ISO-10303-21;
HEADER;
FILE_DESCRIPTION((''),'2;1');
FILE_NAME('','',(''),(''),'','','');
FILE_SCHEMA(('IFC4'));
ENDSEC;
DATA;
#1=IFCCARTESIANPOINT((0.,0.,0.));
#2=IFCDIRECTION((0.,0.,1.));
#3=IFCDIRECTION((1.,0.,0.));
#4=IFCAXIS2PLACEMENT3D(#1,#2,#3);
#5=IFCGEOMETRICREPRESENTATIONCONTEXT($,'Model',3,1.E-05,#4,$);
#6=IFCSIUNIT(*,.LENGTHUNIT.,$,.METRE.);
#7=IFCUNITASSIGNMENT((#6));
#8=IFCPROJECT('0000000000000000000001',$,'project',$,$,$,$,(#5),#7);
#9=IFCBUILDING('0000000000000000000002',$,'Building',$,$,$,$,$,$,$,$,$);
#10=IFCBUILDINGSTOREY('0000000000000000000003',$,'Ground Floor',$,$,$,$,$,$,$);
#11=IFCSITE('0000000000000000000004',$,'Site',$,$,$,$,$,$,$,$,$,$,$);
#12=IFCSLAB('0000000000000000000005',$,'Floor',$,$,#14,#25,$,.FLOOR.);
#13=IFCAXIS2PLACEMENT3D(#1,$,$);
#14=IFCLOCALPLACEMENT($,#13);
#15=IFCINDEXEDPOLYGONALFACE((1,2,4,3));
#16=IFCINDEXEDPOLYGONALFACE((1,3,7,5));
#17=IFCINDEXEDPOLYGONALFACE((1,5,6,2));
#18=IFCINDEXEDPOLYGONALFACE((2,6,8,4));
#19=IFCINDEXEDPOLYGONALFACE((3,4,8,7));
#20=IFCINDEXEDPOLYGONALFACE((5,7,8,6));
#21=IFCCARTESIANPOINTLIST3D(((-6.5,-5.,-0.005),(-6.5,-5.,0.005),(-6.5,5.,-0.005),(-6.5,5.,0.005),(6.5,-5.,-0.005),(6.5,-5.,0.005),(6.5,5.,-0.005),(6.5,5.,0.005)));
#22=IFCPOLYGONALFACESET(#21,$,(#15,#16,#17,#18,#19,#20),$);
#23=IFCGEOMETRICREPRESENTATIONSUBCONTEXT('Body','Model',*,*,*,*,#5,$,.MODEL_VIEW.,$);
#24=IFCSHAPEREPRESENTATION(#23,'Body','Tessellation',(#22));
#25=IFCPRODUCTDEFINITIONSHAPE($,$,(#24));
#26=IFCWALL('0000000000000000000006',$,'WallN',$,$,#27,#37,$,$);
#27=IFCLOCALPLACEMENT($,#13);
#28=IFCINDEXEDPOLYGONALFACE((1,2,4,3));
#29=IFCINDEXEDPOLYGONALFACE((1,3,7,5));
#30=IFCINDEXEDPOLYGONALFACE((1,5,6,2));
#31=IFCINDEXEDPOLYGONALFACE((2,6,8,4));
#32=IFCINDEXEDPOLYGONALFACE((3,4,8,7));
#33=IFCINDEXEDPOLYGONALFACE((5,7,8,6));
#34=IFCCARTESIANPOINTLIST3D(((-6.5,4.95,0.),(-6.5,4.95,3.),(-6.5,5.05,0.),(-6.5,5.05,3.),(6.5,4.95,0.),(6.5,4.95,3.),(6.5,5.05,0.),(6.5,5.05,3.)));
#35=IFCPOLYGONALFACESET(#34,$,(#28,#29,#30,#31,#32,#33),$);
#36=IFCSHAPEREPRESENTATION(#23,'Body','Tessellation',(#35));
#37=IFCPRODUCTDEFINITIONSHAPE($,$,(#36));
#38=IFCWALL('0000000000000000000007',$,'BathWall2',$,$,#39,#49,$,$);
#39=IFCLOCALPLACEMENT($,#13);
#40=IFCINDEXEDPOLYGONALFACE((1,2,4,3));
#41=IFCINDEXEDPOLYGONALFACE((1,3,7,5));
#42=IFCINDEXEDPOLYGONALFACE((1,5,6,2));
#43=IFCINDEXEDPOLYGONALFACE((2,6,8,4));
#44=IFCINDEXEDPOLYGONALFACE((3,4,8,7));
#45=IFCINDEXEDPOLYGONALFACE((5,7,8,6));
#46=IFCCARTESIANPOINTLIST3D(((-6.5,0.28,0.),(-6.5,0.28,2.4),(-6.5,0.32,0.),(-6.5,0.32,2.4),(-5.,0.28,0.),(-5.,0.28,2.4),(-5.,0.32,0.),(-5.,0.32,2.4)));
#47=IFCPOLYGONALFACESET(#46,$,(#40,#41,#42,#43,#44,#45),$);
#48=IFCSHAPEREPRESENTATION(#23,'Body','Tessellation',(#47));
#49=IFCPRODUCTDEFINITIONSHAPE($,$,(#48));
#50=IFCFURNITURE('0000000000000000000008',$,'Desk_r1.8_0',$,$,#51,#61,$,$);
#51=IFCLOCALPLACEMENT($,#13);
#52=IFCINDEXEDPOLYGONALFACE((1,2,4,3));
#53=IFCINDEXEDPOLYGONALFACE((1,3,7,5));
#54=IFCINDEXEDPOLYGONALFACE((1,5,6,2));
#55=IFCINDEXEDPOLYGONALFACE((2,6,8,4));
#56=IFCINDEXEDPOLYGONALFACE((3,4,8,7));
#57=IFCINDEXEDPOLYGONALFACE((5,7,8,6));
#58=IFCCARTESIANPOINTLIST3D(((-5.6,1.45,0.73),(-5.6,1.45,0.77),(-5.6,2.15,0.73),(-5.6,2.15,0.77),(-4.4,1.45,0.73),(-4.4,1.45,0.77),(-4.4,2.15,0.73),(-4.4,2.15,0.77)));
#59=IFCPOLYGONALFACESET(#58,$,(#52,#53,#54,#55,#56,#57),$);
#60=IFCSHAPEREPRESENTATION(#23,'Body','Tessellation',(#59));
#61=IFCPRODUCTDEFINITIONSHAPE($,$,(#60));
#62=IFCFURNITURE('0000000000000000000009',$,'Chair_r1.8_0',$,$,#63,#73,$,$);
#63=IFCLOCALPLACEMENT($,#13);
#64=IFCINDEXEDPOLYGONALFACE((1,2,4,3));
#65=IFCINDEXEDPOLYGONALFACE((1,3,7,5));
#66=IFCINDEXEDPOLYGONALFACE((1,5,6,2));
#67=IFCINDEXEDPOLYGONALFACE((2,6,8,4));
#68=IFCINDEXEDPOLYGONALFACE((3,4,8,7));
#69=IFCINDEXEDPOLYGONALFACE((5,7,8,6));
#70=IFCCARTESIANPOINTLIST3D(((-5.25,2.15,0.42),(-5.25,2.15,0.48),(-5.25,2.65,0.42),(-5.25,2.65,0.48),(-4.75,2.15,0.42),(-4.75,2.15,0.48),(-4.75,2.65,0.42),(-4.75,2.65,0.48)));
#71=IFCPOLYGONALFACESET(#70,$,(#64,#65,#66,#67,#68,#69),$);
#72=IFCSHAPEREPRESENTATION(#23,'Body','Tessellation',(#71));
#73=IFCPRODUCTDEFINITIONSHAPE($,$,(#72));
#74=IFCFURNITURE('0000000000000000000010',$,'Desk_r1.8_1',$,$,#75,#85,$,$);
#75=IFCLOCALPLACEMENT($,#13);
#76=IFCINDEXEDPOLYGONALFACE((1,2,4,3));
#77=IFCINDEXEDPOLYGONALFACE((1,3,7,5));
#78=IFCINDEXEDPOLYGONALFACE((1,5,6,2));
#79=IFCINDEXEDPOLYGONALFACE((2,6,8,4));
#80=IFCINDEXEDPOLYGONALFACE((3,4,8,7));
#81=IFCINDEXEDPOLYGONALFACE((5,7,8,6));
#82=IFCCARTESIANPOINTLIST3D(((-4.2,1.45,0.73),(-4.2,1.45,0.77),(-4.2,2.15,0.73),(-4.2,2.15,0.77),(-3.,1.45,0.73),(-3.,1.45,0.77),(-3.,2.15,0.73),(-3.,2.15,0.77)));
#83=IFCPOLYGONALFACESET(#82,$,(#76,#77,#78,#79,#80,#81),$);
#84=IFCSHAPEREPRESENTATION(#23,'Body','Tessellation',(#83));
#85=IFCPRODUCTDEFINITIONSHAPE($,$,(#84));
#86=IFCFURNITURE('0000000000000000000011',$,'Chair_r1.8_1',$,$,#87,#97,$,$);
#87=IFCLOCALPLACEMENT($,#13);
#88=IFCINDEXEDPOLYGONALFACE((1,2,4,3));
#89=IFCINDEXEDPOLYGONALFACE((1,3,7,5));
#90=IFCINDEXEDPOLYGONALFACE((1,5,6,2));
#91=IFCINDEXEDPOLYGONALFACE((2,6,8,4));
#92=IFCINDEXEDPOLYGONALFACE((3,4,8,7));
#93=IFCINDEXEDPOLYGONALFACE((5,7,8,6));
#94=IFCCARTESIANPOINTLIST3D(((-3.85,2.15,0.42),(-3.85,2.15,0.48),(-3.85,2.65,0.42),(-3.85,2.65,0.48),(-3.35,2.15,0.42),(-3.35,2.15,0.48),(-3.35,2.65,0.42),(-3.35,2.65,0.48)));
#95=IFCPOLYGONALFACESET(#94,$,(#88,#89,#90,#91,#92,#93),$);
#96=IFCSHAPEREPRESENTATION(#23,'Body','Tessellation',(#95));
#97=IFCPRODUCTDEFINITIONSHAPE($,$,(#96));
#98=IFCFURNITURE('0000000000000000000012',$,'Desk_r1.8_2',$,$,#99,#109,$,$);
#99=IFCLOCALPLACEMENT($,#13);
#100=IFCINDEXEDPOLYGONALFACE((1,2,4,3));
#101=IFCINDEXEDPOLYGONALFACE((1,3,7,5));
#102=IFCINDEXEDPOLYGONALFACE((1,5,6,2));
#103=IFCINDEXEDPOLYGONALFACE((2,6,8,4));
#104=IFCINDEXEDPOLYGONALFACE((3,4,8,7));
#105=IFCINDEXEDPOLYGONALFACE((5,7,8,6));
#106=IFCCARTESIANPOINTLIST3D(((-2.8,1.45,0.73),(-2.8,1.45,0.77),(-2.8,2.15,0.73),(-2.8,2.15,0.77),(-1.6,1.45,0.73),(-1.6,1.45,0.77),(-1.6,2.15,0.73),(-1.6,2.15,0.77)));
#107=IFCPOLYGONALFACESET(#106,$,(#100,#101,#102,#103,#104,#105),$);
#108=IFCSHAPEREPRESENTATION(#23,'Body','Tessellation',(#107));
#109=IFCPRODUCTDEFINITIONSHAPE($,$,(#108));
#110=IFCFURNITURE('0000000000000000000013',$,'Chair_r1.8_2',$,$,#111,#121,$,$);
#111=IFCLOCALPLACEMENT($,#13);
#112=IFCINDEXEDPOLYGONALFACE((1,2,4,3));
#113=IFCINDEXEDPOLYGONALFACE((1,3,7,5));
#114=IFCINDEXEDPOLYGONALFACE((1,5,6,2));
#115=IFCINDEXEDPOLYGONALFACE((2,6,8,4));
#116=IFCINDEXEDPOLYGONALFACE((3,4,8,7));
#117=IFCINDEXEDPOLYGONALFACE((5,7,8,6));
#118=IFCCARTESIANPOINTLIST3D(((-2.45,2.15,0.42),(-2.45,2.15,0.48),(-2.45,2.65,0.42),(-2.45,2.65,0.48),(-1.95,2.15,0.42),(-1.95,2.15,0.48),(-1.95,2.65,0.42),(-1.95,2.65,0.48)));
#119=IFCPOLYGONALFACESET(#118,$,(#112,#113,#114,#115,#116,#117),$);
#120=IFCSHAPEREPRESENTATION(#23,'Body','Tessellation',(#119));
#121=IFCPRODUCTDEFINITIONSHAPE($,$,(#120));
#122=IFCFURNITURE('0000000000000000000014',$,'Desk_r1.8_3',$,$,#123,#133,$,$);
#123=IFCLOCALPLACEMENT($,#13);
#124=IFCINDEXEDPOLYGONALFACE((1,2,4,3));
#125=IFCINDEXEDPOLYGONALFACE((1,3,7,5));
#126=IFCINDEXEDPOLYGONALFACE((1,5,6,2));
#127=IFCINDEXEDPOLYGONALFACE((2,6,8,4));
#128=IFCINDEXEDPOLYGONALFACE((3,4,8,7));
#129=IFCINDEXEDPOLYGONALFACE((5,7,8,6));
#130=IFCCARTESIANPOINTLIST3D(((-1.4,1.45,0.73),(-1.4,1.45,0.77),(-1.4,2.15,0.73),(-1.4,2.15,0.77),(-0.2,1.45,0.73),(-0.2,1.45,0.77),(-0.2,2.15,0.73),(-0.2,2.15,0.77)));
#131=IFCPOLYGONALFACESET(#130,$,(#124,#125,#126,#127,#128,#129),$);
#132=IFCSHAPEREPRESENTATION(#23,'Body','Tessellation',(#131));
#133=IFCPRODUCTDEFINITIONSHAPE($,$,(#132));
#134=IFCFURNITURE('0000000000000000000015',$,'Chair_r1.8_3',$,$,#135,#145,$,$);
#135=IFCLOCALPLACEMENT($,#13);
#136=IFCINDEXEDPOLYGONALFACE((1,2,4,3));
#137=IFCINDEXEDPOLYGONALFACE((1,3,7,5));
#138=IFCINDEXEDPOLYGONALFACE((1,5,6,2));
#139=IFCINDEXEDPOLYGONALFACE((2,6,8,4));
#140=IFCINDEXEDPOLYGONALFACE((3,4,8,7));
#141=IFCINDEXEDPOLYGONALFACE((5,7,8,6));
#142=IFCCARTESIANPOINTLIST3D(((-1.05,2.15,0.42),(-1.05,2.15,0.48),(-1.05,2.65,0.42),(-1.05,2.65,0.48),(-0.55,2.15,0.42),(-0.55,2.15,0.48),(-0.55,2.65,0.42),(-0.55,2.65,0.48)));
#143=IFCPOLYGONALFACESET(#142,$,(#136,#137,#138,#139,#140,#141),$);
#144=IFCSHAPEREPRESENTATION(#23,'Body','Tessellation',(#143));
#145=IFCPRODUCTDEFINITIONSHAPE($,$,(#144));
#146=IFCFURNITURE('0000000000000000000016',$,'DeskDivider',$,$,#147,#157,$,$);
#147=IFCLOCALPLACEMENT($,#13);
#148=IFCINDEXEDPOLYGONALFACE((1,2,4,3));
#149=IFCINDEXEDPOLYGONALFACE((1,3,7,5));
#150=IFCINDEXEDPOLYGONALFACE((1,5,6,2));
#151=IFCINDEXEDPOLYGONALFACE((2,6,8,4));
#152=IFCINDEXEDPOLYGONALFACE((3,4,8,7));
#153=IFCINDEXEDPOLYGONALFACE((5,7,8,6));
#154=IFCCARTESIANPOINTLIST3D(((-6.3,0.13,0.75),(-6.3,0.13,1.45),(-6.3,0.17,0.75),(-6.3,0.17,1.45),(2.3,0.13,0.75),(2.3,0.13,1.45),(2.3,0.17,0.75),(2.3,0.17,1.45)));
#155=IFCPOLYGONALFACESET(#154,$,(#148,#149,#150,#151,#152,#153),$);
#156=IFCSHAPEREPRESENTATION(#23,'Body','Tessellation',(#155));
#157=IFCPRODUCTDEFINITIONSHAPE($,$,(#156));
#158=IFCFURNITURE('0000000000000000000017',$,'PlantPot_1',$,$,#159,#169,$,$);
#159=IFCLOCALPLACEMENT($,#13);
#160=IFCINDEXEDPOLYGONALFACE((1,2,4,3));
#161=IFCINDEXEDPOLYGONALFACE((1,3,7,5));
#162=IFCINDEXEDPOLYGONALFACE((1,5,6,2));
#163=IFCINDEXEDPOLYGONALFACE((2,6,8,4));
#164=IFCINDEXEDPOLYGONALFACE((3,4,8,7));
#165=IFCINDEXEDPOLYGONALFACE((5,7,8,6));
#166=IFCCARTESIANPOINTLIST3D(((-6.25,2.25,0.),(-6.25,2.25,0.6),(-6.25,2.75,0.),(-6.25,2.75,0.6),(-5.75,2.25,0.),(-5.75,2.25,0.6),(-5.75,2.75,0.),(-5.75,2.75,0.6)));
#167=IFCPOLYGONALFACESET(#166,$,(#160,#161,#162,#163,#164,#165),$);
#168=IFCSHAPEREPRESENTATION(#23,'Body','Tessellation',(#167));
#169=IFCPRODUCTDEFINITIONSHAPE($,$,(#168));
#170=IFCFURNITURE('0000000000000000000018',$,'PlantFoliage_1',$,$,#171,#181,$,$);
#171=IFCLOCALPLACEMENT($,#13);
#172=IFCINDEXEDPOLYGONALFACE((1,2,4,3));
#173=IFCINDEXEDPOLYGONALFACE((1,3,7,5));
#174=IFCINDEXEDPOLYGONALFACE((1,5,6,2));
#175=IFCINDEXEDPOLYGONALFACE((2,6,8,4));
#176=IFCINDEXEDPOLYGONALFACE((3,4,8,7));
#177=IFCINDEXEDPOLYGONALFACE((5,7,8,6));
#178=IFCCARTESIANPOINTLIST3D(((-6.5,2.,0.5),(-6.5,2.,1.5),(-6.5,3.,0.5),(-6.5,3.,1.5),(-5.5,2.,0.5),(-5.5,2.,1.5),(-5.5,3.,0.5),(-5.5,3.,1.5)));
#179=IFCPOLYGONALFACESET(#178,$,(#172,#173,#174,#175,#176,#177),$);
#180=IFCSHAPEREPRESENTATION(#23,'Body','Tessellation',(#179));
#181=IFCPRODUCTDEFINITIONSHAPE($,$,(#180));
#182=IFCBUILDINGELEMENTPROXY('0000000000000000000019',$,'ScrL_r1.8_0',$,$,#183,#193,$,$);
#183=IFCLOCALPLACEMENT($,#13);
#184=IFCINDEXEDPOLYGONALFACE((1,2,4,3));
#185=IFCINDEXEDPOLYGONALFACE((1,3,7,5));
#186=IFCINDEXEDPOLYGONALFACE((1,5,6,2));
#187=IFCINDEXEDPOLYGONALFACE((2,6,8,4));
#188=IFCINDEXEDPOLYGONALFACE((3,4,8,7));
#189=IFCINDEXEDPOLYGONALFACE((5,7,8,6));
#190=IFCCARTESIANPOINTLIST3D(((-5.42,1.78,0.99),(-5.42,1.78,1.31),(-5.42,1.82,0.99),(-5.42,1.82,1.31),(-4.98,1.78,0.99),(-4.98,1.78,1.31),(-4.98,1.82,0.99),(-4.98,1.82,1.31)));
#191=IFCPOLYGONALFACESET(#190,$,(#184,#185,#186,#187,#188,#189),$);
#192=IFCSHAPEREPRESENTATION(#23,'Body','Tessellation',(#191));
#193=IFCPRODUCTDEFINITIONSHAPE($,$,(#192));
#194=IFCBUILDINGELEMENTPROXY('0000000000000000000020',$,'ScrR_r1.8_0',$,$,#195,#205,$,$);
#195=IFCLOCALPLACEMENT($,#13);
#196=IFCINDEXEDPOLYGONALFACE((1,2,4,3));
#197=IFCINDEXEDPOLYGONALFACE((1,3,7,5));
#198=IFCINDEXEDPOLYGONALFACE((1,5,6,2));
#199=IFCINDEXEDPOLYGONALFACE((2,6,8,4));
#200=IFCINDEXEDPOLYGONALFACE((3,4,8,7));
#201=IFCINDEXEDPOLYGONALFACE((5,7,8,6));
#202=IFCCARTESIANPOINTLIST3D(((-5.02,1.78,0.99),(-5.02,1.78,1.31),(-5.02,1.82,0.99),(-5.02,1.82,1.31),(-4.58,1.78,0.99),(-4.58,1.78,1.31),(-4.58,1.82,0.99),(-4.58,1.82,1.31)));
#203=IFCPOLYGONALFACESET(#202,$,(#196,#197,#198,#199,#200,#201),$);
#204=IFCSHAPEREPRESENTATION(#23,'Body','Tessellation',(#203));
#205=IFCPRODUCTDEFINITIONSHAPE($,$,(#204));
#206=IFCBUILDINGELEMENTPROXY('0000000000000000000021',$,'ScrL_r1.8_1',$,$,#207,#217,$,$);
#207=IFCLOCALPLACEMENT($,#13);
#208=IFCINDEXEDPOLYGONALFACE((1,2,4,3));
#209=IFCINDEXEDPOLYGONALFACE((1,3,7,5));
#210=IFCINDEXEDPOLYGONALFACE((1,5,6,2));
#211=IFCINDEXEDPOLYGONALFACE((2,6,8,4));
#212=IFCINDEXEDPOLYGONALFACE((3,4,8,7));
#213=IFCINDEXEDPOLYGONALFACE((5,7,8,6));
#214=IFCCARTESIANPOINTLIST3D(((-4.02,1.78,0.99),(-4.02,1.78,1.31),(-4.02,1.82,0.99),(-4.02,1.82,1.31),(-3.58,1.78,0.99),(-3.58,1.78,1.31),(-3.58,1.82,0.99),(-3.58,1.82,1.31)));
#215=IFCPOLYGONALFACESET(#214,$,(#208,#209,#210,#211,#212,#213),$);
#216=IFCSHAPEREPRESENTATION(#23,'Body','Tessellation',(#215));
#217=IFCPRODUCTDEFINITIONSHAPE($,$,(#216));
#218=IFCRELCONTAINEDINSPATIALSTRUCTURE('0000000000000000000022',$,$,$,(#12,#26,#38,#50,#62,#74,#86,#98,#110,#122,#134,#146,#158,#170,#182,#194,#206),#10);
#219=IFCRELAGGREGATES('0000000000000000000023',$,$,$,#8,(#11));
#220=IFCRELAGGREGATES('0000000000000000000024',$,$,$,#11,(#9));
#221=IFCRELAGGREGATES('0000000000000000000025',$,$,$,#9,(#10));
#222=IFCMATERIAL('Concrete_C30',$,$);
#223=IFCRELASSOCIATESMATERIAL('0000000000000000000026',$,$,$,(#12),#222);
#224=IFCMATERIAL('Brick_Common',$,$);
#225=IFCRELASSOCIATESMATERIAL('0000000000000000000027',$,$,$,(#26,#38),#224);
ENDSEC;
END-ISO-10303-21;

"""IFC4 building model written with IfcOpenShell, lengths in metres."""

from ifc_helpers import new_model, si_unit, frame, origin_with_axes, origin_2d, place, context, subcontext, project, spatial, rectangle, extrude, material, element, save


model = new_model("IFC4")

# Units and contexts
model_context = context("Model", 3, precision=1e-05, world=origin_with_axes())
body_context = subcontext(model_context, "Body", "Model", "MODEL_VIEW")
ifc_project = project(units=[si_unit("LENGTHUNIT", "METRE")], contexts=[model_context])

# Site, building, storey
site = spatial("IfcSite", under=ifc_project, Name="Site")
building = spatial("IfcBuilding", under=site, Name="Building")
storey = spatial("IfcBuildingStorey", under=building, Name="Ground Floor")

# Slab
ifc_material_1 = material(Name="Concrete_C30")
slab_placement = place(None, origin_with_axes())
element("IfcSlab", 1, at=slab_placement, inside=storey, material=ifc_material_1, Name="Floor", PredefinedType="FLOOR", context=body_context, shape_type="SweptSolid", body=[
    extrude(rectangle(XDim=13.0, YDim=10.0, at=origin_2d()), frame((0.0, 0.0, -0.005)), (0.0, 0.0, 1.0), 0.01),
])

# Walls
ifc_material_2 = material(Name="Brick_Common")
wall_1_placement = place(None, frame((0.0, 5.0, 1.5), z_axis=(0.0, 0.0, 1.0), x_axis=(1.0, 0.0, 0.0)))
element("IfcWall", 2, at=wall_1_placement, inside=storey, material=ifc_material_2, Name="WallN", context=body_context, shape_type="SweptSolid", body=[
    extrude(rectangle(XDim=13.0, YDim=0.1, at=origin_2d()), frame((0.0, 0.0, -1.5)), (0.0, 0.0, 1.0), 3.0),
])
wall_2_placement = place(None, frame((-5.75, 0.3, 1.2), z_axis=(0.0, 0.0, 1.0), x_axis=(1.0, 0.0, 0.0)))
element("IfcWall", 3, at=wall_2_placement, inside=storey, material=ifc_material_2, Name="BathWall2", context=body_context, shape_type="SweptSolid", body=[
    extrude(rectangle(XDim=1.5, YDim=0.04, at=origin_2d()), frame((0.0, 0.0, -1.2)), (0.0, 0.0, 1.0), 2.4),
])

# Furniture
furniture_1_placement = place(None, frame((-5.0, 1.8, 0.75), z_axis=(0.0, 0.0, 1.0), x_axis=(1.0, 0.0, 0.0)))
element("IfcFurniture", 4, at=furniture_1_placement, inside=storey, Name="Desk_r1.8_0", context=body_context, shape_type="SweptSolid", body=[
    extrude(rectangle(XDim=1.2, YDim=0.7, at=origin_2d()), frame((0.0, 0.0, -0.02)), (0.0, 0.0, 1.0), 0.04),
])
furniture_2_placement = place(None, frame((-5.0, 2.4, 0.45), z_axis=(0.0, 0.0, 1.0), x_axis=(1.0, 0.0, 0.0)))
element("IfcFurniture", 5, at=furniture_2_placement, inside=storey, Name="Chair_r1.8_0", context=body_context, shape_type="SweptSolid", body=[
    extrude(rectangle(XDim=0.5, YDim=0.5, at=origin_2d()), frame((0.0, 0.0, -0.03)), (0.0, 0.0, 1.0), 0.06),
])
furniture_3_placement = place(None, frame((-3.6, 1.8, 0.75), z_axis=(0.0, 0.0, 1.0), x_axis=(1.0, 0.0, 0.0)))
element("IfcFurniture", 6, at=furniture_3_placement, inside=storey, Name="Desk_r1.8_1", context=body_context, shape_type="SweptSolid", body=[
    extrude(rectangle(XDim=1.2, YDim=0.7, at=origin_2d()), frame((0.0, 0.0, -0.02)), (0.0, 0.0, 1.0), 0.04),
])
furniture_4_placement = place(None, frame((-3.6, 2.4, 0.45), z_axis=(0.0, 0.0, 1.0), x_axis=(1.0, 0.0, 0.0)))
element("IfcFurniture", 7, at=furniture_4_placement, inside=storey, Name="Chair_r1.8_1", context=body_context, shape_type="SweptSolid", body=[
    extrude(rectangle(XDim=0.5, YDim=0.5, at=origin_2d()), frame((0.0, 0.0, -0.03)), (0.0, 0.0, 1.0), 0.06),
])
furniture_5_placement = place(None, frame((-2.2, 1.8, 0.75), z_axis=(0.0, 0.0, 1.0), x_axis=(1.0, 0.0, 0.0)))
element("IfcFurniture", 8, at=furniture_5_placement, inside=storey, Name="Desk_r1.8_2", context=body_context, shape_type="SweptSolid", body=[
    extrude(rectangle(XDim=1.2, YDim=0.7, at=origin_2d()), frame((0.0, 0.0, -0.02)), (0.0, 0.0, 1.0), 0.04),
])
furniture_6_placement = place(None, frame((-2.2, 2.4, 0.45), z_axis=(0.0, 0.0, 1.0), x_axis=(1.0, 0.0, 0.0)))
element("IfcFurniture", 9, at=furniture_6_placement, inside=storey, Name="Chair_r1.8_2", context=body_context, shape_type="SweptSolid", body=[
    extrude(rectangle(XDim=0.5, YDim=0.5, at=origin_2d()), frame((0.0, 0.0, -0.03)), (0.0, 0.0, 1.0), 0.06),
])
furniture_7_placement = place(None, frame((-0.8, 1.8, 0.75), z_axis=(0.0, 0.0, 1.0), x_axis=(1.0, 0.0, 0.0)))
element("IfcFurniture", 10, at=furniture_7_placement, inside=storey, Name="Desk_r1.8_3", context=body_context, shape_type="SweptSolid", body=[
    extrude(rectangle(XDim=1.2, YDim=0.7, at=origin_2d()), frame((0.0, 0.0, -0.02)), (0.0, 0.0, 1.0), 0.04),
])
furniture_8_placement = place(None, frame((-0.8, 2.4, 0.45), z_axis=(0.0, 0.0, 1.0), x_axis=(1.0, 0.0, 0.0)))
element("IfcFurniture", 11, at=furniture_8_placement, inside=storey, Name="Chair_r1.8_3", context=body_context, shape_type="SweptSolid", body=[
    extrude(rectangle(XDim=0.5, YDim=0.5, at=origin_2d()), frame((0.0, 0.0, -0.03)), (0.0, 0.0, 1.0), 0.06),
])
furniture_9_placement = place(None, frame((-2.0, 0.15, 1.1), z_axis=(0.0, 0.0, 1.0), x_axis=(1.0, 0.0, 0.0)))
element("IfcFurniture", 12, at=furniture_9_placement, inside=storey, Name="DeskDivider", context=body_context, shape_type="SweptSolid", body=[
    extrude(rectangle(XDim=8.6, YDim=0.04, at=origin_2d()), frame((0.0, 0.0, -0.35)), (0.0, 0.0, 1.0), 0.7),
])
furniture_10_placement = place(None, frame((-6.0, 2.5, 0.3), z_axis=(0.0, 0.0, 1.0), x_axis=(1.0, 0.0, 0.0)))
element("IfcFurniture", 13, at=furniture_10_placement, inside=storey, Name="PlantPot_1", context=body_context, shape_type="SweptSolid", body=[
    extrude(rectangle(XDim=0.5, YDim=0.5, at=origin_2d()), frame((0.0, 0.0, -0.3)), (0.0, 0.0, 1.0), 0.6),
])
furniture_11_placement = place(None, frame((-6.0, 2.5, 1.0), z_axis=(0.0, 0.0, 1.0), x_axis=(1.0, 0.0, 0.0)))
element("IfcFurniture", 14, at=furniture_11_placement, inside=storey, Name="PlantFoliage_1", context=body_context, shape_type="SweptSolid", body=[
    extrude(rectangle(XDim=1.0, YDim=1.0, at=origin_2d()), frame((0.0, 0.0, -0.5)), (0.0, 0.0, 1.0), 1.0),
])

# Building element proxies
for number, where, z_axis, x_axis, name in (
    (15, (-5.2, 1.8, 1.15), (0.0, 0.0, 1.0), (1.0, 0.0, 0.0), "ScrL_r1.8_0"),
    (16, (-4.8, 1.8, 1.15), (0.0, 0.0, 1.0), (1.0, 0.0, 0.0), "ScrR_r1.8_0"),
    (17, (-3.8, 1.8, 1.15), (0.0, 0.0, 1.0), (1.0, 0.0, 0.0), "ScrL_r1.8_1"),
):
    element("IfcBuildingElementProxy", number, at=place(None, frame(where, z_axis=z_axis, x_axis=x_axis)), inside=storey, Name=name, context=body_context, shape_type="SweptSolid", body=[
        extrude(rectangle(XDim=0.44, YDim=0.04, at=origin_2d()), frame((0.0, 0.0, -0.16)), (0.0, 0.0, 1.0), 0.32),
    ])

save(model, "model.ifc")
